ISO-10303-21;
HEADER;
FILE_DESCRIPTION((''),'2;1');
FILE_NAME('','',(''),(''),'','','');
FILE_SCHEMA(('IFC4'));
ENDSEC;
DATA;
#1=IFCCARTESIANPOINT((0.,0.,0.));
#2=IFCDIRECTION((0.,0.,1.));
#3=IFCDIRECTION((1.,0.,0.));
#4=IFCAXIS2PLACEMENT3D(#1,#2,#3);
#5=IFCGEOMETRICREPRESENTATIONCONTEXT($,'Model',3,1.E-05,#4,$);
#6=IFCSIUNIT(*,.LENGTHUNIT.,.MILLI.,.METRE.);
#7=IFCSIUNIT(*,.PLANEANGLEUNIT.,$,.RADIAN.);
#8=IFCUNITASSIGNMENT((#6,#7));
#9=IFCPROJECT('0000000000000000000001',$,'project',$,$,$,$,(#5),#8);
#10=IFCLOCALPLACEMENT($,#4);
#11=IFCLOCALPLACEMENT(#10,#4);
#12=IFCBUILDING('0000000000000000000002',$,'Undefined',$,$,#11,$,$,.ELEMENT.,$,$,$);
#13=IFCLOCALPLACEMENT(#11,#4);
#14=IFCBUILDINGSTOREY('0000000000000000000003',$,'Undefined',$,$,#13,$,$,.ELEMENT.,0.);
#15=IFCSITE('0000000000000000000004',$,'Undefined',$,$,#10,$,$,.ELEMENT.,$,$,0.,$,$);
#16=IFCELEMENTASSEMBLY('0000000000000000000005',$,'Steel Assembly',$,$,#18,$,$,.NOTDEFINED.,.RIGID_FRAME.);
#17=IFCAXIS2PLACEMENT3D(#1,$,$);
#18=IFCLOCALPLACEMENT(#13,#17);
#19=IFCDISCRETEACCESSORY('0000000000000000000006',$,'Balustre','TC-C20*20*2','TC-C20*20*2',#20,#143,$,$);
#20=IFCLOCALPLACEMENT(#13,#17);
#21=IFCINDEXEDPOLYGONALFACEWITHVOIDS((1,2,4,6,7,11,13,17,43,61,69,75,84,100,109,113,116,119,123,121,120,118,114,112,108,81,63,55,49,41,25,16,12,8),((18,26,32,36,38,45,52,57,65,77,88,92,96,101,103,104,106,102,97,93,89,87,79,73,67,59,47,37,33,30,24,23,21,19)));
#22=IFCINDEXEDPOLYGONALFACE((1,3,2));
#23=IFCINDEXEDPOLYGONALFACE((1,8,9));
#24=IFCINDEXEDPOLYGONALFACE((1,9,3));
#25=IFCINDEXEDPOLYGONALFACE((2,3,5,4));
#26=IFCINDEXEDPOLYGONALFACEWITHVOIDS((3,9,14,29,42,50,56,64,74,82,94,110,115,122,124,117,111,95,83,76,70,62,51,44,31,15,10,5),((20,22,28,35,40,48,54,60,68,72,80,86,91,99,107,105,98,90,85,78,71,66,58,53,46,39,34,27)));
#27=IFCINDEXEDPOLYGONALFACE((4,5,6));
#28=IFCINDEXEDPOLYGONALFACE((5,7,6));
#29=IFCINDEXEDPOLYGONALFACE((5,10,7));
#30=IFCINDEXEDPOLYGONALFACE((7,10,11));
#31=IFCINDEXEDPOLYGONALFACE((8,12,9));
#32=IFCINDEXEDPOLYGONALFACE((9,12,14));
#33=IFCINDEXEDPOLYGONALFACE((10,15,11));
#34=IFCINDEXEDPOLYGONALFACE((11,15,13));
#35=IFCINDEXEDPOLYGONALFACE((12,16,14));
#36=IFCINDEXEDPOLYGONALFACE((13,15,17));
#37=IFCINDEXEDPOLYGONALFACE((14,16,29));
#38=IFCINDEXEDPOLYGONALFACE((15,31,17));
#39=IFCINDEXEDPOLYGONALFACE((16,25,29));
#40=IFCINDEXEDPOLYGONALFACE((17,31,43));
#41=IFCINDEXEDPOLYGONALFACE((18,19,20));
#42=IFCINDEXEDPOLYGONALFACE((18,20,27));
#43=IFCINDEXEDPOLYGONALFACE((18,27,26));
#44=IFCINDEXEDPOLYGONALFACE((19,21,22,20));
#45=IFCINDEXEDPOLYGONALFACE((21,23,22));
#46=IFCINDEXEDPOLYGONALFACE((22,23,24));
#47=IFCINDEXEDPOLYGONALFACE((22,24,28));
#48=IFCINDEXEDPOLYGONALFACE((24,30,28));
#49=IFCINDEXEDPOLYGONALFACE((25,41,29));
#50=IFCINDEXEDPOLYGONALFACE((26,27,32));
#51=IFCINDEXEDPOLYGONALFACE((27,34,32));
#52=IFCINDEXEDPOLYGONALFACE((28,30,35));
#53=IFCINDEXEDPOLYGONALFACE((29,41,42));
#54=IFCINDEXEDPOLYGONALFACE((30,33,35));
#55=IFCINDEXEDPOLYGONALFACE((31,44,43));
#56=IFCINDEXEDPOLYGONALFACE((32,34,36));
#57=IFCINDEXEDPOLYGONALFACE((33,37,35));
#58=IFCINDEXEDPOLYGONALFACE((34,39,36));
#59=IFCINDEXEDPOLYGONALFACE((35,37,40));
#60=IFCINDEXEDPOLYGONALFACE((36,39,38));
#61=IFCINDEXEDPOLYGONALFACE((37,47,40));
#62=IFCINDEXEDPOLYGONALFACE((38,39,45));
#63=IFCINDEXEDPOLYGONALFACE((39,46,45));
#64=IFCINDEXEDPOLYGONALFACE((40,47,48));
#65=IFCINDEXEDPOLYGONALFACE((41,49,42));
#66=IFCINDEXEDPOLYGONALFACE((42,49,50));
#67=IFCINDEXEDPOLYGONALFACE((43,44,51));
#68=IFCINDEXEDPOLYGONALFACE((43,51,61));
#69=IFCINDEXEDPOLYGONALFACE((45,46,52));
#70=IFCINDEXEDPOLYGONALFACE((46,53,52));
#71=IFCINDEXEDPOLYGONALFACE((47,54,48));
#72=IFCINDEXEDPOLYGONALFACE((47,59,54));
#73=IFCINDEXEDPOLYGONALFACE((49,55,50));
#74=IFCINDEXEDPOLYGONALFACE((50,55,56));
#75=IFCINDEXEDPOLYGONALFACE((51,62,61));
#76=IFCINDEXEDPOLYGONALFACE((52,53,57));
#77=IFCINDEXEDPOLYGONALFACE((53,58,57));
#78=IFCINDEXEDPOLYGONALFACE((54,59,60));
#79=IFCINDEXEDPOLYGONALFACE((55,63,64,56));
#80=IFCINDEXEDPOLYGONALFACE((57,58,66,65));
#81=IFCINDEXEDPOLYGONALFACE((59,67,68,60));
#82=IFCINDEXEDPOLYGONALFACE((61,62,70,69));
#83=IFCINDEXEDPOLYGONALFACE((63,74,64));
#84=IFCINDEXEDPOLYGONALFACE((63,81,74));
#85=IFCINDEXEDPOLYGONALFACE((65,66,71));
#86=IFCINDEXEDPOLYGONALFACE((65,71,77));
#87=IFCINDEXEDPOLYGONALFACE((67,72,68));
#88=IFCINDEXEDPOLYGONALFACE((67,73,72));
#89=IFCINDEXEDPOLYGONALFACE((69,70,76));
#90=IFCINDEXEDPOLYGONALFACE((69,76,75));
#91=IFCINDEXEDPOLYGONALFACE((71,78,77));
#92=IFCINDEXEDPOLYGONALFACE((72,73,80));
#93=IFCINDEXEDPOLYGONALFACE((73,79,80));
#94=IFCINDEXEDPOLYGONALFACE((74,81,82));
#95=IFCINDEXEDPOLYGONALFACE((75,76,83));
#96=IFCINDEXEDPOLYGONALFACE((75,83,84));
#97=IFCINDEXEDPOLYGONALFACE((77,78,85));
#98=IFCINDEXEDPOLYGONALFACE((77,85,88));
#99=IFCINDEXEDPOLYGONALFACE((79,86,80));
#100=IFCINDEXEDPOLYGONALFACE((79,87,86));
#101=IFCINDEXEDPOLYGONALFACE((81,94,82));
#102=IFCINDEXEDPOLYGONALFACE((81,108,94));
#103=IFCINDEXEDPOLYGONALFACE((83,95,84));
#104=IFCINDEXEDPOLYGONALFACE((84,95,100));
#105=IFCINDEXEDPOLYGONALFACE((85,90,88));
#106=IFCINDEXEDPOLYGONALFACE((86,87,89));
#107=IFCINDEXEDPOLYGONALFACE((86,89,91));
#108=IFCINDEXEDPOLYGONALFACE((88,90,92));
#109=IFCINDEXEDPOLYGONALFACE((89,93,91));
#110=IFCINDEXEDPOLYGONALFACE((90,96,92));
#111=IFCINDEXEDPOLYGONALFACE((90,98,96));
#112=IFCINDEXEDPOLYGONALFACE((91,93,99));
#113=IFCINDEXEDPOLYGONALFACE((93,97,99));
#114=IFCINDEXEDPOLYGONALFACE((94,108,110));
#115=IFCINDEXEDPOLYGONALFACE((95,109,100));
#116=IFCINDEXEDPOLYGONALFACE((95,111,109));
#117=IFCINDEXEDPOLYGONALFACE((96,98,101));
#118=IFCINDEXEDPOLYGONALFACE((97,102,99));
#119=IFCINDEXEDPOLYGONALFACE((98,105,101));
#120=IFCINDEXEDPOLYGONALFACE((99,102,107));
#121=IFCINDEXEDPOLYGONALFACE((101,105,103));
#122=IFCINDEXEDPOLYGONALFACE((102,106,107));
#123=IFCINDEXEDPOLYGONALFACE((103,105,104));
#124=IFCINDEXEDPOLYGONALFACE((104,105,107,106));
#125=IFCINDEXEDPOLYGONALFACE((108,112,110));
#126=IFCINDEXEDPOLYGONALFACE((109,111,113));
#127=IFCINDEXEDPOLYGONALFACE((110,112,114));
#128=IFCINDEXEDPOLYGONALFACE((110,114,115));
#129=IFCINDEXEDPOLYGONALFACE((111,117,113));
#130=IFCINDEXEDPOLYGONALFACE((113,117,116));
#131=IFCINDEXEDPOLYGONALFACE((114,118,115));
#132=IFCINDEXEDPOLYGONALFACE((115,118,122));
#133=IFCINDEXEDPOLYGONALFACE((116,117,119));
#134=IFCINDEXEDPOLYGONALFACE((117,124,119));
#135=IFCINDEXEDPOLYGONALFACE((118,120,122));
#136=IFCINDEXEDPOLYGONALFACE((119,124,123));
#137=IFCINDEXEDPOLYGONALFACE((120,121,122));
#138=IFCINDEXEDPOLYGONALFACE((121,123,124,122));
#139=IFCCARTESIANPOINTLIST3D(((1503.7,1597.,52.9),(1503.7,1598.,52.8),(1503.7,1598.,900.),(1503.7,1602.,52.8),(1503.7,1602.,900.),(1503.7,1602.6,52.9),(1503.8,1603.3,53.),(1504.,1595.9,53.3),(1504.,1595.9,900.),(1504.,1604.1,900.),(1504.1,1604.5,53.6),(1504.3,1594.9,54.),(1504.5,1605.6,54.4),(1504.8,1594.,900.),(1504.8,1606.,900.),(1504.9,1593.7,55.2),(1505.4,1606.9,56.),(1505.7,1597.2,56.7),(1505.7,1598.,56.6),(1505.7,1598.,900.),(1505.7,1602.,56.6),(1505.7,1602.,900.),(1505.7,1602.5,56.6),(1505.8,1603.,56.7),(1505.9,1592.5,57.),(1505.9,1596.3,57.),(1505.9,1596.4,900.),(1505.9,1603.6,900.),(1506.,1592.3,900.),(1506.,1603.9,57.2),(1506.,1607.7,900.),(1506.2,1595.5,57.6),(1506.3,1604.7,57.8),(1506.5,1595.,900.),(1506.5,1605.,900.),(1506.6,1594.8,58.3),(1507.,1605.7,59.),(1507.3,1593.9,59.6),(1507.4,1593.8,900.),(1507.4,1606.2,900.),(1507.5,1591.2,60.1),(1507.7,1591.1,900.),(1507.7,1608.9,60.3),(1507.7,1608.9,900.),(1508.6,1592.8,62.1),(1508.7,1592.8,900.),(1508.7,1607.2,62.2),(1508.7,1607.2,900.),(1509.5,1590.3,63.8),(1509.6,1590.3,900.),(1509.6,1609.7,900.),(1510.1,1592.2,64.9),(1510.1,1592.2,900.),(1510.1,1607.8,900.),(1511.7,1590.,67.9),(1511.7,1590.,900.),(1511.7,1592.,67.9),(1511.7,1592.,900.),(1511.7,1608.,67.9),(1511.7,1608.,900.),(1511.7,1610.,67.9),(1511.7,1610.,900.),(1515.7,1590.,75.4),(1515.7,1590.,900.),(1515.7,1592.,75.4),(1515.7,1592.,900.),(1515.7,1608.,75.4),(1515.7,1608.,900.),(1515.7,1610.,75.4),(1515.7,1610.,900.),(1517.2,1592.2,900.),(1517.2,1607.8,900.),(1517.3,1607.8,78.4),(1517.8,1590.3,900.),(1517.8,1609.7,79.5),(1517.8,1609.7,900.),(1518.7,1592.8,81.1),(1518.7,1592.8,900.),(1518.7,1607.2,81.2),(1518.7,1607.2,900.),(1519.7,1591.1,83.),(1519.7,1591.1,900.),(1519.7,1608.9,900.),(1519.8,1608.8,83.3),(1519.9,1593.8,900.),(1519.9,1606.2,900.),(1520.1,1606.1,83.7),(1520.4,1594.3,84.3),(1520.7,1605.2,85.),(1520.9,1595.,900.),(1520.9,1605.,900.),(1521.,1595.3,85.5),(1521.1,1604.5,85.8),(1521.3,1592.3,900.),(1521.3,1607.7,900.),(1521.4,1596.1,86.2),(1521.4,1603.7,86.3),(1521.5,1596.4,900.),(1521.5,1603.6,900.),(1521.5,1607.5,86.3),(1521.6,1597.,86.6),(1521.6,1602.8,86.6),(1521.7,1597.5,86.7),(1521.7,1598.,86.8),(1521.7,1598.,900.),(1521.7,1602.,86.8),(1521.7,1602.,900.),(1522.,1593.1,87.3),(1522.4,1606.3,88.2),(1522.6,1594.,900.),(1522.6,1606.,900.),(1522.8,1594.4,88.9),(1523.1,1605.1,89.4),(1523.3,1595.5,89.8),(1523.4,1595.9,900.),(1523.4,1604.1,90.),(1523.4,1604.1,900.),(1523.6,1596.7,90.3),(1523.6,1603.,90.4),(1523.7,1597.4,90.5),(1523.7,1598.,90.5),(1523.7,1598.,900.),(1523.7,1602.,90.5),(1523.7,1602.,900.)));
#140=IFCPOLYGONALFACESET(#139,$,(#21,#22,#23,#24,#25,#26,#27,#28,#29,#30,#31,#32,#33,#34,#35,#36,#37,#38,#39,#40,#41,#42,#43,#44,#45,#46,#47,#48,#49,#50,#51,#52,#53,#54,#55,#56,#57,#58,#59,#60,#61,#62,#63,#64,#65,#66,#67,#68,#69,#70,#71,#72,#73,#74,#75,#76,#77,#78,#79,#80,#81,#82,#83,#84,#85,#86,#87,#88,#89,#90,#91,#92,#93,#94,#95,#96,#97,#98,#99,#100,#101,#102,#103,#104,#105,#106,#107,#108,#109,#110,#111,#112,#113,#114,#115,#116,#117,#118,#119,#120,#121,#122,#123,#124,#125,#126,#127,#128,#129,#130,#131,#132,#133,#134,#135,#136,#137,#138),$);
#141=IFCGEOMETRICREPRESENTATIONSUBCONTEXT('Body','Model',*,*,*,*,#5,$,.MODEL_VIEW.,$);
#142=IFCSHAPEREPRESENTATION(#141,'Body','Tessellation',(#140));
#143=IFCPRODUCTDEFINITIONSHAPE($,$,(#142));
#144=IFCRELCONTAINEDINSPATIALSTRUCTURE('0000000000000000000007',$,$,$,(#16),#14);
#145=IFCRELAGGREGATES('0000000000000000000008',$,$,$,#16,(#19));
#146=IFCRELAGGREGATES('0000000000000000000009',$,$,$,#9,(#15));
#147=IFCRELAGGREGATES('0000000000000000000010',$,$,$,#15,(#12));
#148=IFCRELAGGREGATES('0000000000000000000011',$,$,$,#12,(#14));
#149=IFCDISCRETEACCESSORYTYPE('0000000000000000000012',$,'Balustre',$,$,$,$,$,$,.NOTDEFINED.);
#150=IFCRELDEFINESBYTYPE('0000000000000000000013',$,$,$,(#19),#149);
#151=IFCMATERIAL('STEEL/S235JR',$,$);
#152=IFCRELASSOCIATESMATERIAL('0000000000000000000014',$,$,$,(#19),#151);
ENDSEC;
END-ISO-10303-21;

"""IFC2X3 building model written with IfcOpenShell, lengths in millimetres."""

from ifc_helpers import new_model, si_unit, frame, origin_with_axes, origin_2d_with_axis, place, context, subcontext, project, spatial, hollow_rectangle, extrude, clip, halfspace, material, type_object, element, aggregate, save


model = new_model("IFC2X3")

# Units and contexts
model_context = context("Model", 3, precision=1e-05, world=origin_with_axes())
body_context = subcontext(model_context, "Body", "Model", "MODEL_VIEW")
ifc_project = project(units=[si_unit("LENGTHUNIT", "METRE", prefix="MILLI"), si_unit("PLANEANGLEUNIT", "RADIAN")], contexts=[model_context])

# Site, building, storey
site_placement = place(None, origin_with_axes())
site = spatial("IfcSite", under=ifc_project, at=site_placement, Name="Undefined", CompositionType="ELEMENT", RefElevation=0.0)
building_placement = place(site_placement, origin_with_axes())
building = spatial("IfcBuilding", under=site, at=building_placement, Name="Undefined", CompositionType="ELEMENT")
storey_placement = place(building_placement, origin_with_axes())
storey = spatial("IfcBuildingStorey", under=building, at=storey_placement, Name="Undefined", CompositionType="ELEMENT", Elevation=0.0)

# Element assembly
ifc_material = material(Name="STEEL/S235JR")
assembly_1_placement = place(storey_placement, origin_with_axes())
assembly_1 = element("IfcElementAssembly", 1, at=assembly_1_placement, inside=storey, Name="Steel Assembly", AssemblyPlace="NOTDEFINED", PredefinedType="RIGID_FRAME")

# Discrete accessory
discrete_accessory_type_1 = type_object("IfcDiscreteAccessoryType", Name="Balustre")
discrete_accessory_1_placement = place(assembly_1_placement, frame((1513.7, 1600.0, 900.0), z_axis=(-0.000011, 1.0, 0.0), x_axis=(0.0, 0.0, -1.0)))
discrete_accessory_1 = element("IfcDiscreteAccessory", 2, at=discrete_accessory_1_placement, type_object=discrete_accessory_type_1, material=ifc_material, Name="Balustre", Description="TC-C20*20*2", ObjectType="TC-C20*20*2", context=body_context, shape_type="Clipping", body=[
    clip(extrude(hollow_rectangle(XDim=20.0, YDim=20.0, WallThickness=2.0, InnerFilletRadius=6.0, OuterFilletRadius=8.0, at=origin_2d_with_axis()), frame((847.4, 0.0, 0.0), z_axis=(-1.0, 0.0, 0.0), x_axis=(0.0, -1.0, 0.0)), (0.0, 0.0, 1.0), 847.4), halfspace(frame((855.2, 14.2, 0.0), z_axis=(-0.46842, 0.883506, 0.000005), x_axis=(0.0, -0.000005, 1.0)), True)),
])
aggregate(assembly_1, [discrete_accessory_1])

save(model, "model.ifc")
